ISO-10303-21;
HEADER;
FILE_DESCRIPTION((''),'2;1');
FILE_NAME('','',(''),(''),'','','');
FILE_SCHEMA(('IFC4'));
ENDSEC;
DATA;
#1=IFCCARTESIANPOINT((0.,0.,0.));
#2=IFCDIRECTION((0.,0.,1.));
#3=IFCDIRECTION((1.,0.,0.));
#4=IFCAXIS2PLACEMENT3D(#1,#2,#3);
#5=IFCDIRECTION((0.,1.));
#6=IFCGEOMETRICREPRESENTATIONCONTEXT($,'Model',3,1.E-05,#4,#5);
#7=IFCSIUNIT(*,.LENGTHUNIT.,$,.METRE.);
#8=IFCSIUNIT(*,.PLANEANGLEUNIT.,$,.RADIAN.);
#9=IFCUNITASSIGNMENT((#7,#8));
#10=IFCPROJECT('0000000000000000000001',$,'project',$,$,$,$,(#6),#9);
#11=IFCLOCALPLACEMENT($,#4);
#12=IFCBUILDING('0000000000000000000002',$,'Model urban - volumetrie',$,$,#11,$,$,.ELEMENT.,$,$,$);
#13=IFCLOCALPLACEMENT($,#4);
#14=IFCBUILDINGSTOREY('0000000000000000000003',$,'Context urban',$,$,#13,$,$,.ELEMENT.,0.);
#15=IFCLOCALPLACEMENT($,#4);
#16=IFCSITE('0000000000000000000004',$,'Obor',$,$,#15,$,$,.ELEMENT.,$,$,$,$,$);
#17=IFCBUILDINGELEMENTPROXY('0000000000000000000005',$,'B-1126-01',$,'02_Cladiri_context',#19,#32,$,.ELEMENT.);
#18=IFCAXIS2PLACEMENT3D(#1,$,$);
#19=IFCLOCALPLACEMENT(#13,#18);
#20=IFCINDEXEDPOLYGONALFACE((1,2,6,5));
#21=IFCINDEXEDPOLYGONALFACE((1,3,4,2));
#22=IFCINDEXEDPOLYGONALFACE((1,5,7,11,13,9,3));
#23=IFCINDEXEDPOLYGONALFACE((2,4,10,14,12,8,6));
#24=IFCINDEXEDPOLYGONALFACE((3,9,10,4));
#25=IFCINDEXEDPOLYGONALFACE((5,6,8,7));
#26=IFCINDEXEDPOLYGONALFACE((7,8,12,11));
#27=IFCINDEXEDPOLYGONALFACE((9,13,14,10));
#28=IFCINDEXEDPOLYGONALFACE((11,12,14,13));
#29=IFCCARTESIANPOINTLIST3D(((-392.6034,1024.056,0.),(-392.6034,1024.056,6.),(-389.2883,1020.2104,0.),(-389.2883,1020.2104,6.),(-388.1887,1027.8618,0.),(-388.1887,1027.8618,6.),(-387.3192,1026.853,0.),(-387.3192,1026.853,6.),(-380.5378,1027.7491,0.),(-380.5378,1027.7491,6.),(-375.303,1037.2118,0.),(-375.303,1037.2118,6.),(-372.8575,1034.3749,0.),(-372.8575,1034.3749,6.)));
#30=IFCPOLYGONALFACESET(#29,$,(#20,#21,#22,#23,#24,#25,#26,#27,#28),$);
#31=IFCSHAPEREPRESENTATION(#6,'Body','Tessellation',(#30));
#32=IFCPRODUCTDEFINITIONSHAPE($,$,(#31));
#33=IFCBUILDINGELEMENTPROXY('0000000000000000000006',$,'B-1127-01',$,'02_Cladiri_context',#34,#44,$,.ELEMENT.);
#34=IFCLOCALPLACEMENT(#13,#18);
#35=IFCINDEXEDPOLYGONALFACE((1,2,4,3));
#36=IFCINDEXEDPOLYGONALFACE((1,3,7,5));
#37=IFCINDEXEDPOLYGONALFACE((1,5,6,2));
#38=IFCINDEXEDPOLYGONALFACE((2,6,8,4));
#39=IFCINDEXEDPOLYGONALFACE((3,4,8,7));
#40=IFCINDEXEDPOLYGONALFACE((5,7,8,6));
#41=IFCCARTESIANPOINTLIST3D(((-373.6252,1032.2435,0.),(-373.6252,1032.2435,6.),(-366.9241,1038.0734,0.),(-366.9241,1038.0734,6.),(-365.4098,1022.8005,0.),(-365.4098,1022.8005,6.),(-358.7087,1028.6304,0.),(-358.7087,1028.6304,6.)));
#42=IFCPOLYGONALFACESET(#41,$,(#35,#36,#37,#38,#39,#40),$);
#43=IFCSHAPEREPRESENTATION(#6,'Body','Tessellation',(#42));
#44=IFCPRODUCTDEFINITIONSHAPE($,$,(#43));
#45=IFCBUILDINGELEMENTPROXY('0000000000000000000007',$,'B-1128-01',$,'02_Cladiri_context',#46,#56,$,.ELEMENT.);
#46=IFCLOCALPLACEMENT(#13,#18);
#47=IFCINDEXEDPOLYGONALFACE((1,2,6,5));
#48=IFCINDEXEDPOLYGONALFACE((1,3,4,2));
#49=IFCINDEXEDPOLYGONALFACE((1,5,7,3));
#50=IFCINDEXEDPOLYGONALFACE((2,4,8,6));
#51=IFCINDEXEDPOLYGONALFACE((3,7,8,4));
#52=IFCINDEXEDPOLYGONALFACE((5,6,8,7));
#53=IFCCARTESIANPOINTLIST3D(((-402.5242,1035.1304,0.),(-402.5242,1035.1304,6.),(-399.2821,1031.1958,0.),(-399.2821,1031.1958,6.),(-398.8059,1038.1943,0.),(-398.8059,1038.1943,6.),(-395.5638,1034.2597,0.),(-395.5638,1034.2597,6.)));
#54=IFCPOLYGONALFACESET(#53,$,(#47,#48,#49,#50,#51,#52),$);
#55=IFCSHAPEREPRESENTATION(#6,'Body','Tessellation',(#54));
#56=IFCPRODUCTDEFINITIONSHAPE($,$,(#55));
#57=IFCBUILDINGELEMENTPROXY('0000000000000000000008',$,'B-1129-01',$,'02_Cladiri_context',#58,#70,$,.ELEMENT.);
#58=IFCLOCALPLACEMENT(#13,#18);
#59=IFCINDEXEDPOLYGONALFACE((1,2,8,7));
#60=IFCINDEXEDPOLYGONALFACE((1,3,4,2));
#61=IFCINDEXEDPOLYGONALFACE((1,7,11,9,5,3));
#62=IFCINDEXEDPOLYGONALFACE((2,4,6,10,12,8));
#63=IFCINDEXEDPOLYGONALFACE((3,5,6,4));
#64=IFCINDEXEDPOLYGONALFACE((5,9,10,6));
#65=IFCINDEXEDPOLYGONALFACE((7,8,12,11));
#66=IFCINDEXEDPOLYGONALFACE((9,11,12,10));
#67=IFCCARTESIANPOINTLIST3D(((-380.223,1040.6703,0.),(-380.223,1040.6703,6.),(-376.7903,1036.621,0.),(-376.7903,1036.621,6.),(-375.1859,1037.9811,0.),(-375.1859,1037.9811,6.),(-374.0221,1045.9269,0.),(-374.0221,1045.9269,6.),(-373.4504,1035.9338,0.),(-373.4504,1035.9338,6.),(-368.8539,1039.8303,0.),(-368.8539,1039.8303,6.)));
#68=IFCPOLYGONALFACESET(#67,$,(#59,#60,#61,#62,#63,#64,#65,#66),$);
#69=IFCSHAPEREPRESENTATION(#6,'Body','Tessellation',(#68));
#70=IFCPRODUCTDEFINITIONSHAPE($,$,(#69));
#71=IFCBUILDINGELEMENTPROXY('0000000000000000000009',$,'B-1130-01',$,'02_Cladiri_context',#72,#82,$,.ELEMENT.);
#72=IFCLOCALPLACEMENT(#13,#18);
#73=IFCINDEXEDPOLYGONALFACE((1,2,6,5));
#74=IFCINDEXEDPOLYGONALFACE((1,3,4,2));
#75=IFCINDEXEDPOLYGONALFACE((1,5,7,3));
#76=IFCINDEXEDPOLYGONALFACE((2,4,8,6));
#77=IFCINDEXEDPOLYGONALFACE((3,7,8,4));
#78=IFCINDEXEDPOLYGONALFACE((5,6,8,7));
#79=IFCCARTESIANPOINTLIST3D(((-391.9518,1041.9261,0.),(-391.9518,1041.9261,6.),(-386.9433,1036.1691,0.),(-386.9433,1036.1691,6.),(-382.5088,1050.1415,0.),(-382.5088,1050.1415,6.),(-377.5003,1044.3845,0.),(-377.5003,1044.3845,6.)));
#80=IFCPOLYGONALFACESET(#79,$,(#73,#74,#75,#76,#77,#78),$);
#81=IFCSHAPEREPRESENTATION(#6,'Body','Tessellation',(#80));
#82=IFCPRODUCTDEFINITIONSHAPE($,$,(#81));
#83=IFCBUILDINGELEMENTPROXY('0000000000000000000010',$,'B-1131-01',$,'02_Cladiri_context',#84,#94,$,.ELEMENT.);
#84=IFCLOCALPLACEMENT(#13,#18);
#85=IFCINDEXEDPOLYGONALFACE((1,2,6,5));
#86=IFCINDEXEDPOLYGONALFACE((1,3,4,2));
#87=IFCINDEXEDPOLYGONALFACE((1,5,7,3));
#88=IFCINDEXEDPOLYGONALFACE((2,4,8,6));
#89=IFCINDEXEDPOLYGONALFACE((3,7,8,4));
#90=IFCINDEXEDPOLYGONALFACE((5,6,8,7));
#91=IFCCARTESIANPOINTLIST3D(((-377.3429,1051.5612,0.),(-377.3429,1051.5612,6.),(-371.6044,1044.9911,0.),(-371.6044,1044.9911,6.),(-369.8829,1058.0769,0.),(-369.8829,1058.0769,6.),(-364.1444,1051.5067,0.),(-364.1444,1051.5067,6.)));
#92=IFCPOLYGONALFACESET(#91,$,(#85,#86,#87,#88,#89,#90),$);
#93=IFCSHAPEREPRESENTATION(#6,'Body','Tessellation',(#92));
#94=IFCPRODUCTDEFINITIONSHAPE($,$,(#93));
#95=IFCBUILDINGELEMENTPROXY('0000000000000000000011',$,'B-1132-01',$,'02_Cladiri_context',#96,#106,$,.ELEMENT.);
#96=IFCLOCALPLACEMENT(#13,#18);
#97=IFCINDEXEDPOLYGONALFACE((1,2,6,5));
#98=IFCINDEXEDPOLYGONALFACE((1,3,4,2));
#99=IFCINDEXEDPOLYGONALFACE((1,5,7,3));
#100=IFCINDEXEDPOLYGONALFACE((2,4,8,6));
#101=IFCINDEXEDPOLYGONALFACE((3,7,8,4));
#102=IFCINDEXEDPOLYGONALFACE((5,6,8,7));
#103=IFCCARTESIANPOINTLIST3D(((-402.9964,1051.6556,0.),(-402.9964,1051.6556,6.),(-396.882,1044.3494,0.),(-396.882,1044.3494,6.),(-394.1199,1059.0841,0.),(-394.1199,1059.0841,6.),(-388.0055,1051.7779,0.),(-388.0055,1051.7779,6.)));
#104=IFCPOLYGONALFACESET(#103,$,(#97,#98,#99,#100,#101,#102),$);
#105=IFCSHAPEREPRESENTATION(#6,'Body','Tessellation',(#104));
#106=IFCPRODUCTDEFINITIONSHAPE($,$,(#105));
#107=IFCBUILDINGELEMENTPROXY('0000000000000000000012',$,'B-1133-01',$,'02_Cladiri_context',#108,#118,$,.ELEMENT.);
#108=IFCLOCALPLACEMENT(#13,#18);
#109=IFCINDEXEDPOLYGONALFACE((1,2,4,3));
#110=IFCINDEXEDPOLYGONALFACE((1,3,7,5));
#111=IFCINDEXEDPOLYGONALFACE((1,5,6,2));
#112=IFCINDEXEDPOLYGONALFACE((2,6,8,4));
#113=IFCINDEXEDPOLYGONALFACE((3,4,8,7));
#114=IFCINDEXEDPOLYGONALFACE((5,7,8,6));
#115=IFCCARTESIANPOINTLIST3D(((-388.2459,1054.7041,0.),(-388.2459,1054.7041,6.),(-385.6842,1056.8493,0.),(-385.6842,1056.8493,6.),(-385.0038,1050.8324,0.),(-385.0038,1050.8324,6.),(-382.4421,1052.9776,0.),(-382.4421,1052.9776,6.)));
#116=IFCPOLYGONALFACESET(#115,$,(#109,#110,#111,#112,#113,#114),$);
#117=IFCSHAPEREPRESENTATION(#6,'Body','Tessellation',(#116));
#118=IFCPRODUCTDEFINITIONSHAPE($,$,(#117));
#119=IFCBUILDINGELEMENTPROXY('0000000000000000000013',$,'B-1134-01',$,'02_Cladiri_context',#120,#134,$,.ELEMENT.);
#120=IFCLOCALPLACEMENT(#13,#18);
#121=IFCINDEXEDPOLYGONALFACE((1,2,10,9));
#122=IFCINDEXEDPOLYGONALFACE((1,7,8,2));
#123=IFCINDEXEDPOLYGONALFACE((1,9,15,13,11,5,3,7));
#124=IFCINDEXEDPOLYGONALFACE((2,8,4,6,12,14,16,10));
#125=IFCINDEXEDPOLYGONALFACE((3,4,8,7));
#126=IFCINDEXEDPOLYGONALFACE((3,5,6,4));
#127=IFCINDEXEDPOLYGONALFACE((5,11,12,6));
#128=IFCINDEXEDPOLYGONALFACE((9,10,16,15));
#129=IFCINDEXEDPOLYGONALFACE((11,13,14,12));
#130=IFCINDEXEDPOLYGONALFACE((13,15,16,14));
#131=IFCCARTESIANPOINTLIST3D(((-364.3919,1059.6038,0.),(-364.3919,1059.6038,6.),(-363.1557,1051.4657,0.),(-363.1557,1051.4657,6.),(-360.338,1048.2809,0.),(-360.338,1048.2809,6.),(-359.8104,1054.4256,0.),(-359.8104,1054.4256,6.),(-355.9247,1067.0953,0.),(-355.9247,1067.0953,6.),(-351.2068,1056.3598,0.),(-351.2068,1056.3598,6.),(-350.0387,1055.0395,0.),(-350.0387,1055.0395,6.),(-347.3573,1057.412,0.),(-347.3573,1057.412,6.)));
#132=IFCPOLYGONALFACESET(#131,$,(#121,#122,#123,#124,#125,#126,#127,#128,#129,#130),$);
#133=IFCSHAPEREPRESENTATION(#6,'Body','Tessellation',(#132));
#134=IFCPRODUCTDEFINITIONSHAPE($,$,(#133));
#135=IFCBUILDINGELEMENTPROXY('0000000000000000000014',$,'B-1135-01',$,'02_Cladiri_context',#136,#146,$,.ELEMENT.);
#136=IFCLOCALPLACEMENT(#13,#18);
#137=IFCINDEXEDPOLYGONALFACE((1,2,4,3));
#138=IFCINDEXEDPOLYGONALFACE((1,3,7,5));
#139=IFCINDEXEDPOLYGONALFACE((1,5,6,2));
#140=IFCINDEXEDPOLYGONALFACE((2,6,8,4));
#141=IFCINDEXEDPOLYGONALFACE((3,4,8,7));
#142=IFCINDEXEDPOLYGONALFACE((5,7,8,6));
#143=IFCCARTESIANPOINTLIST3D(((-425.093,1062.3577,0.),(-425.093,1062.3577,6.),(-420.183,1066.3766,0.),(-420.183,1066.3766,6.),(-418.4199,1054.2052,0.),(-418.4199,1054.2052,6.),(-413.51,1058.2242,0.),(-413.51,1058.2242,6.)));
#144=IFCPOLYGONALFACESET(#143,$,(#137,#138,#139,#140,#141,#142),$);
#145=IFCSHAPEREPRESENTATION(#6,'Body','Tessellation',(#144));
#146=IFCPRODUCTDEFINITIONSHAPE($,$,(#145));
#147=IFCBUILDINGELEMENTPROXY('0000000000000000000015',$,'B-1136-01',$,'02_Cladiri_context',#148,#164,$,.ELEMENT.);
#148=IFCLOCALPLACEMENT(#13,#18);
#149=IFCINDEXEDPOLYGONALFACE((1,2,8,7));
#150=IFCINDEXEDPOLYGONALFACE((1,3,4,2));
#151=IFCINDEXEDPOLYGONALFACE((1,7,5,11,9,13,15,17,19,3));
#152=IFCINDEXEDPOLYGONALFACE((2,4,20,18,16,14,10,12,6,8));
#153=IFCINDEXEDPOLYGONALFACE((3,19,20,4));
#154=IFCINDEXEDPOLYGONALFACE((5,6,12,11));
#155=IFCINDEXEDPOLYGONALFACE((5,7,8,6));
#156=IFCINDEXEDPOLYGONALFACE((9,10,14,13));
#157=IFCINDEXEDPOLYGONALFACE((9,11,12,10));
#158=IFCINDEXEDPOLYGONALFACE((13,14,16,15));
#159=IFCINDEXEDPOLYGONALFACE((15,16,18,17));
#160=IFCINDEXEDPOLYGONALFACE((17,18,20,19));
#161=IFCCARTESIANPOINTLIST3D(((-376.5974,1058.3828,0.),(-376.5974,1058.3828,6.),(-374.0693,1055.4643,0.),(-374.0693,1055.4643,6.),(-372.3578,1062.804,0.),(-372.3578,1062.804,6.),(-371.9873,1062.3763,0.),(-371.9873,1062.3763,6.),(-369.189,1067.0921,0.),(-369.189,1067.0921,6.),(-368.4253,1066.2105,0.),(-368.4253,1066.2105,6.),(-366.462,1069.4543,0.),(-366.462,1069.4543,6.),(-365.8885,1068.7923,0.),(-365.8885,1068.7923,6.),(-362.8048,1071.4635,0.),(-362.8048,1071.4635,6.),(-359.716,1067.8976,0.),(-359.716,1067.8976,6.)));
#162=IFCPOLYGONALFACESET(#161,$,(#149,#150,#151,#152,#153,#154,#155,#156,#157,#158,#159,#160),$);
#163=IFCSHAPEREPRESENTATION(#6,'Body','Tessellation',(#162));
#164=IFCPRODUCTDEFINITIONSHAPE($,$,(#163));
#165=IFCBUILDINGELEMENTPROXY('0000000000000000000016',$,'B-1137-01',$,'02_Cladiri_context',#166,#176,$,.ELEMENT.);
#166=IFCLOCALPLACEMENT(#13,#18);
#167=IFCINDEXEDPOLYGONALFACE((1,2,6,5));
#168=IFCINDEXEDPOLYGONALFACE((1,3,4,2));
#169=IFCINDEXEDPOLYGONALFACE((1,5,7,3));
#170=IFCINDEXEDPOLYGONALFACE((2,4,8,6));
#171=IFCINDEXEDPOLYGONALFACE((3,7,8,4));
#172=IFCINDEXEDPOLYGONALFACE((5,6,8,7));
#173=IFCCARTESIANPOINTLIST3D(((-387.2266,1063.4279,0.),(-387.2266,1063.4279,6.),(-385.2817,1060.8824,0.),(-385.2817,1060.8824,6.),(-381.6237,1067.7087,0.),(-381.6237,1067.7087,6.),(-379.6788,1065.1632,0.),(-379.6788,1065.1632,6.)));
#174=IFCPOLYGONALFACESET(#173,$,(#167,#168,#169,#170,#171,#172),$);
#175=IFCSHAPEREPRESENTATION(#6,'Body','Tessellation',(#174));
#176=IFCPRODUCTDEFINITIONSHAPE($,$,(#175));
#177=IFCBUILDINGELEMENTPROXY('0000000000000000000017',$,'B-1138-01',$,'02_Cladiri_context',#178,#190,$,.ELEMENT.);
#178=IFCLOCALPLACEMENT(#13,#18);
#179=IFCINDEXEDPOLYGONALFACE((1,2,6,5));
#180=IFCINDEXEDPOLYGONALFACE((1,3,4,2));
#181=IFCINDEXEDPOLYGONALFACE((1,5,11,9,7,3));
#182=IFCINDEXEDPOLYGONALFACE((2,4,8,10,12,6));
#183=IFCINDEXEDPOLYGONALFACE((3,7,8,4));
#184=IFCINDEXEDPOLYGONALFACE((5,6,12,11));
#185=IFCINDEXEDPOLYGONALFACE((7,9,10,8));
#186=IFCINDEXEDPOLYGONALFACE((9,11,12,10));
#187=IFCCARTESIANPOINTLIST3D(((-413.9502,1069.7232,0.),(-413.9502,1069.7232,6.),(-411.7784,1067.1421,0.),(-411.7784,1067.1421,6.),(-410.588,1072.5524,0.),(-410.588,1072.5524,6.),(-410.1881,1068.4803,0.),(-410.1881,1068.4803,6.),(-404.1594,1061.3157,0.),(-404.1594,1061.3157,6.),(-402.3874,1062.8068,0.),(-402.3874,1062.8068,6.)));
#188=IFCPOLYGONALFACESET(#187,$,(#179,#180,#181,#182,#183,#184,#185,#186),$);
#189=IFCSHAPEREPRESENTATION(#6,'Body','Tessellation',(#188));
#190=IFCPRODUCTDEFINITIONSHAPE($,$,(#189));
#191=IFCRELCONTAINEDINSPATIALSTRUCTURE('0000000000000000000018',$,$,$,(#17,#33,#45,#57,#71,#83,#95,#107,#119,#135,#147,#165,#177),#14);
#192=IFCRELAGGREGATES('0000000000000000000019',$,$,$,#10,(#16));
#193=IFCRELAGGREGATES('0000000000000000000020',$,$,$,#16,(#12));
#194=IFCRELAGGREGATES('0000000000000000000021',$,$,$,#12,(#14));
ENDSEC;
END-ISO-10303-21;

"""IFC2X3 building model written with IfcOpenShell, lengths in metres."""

from ifc_helpers import new_model, si_unit, direction, origin_with_axes, place, context, project, spatial, polyline, outline, extrude, element, save


model = new_model("IFC2X3")

# Units and contexts
model_context = context("Model", 3, precision=1e-05, world=origin_with_axes(), true_north=direction((0.0, 1.0)))
ifc_project = project(units=[si_unit("LENGTHUNIT", "METRE"), si_unit("PLANEANGLEUNIT", "RADIAN")], contexts=[model_context])

# Site, building, storey
site_placement = place(None, origin_with_axes())
site = spatial("IfcSite", under=ifc_project, at=site_placement, Name="Obor", CompositionType="ELEMENT")
building_placement = place(None, origin_with_axes())
building = spatial("IfcBuilding", under=site, at=building_placement, Name="Model urban - volumetrie", CompositionType="ELEMENT")
storey_placement = place(None, origin_with_axes())
storey = spatial("IfcBuildingStorey", under=building, at=storey_placement, Name="Context urban", CompositionType="ELEMENT", Elevation=0.0)

# Building element proxies
proxy_1_placement = place(None, origin_with_axes())
element("IfcBuildingElementProxy", 1, at=proxy_1_placement, inside=storey, Name="B-1126-01", ObjectType="02_Cladiri_context", CompositionType="ELEMENT", context=model_context, shape_type="SweptSolid", body=[
    extrude(outline(polyline([(-389.2883, 1020.2104), (-380.5378, 1027.7491), (-372.8575, 1034.3749), (-375.303, 1037.2118), (-387.3192, 1026.853), (-388.1887, 1027.8618), (-392.6034, 1024.056), (-389.2883, 1020.2104)])), origin_with_axes(), (0.0, 0.0, 1.0), 6.0),
])
proxy_2_placement = place(None, origin_with_axes())
element("IfcBuildingElementProxy", 2, at=proxy_2_placement, inside=storey, Name="B-1127-01", ObjectType="02_Cladiri_context", CompositionType="ELEMENT", context=model_context, shape_type="SweptSolid", body=[
    extrude(outline(polyline([(-365.4098, 1022.8005), (-358.7087, 1028.6304), (-366.9241, 1038.0734), (-373.6252, 1032.2435), (-365.4098, 1022.8005)])), origin_with_axes(), (0.0, 0.0, 1.0), 6.0),
])
proxy_3_placement = place(None, origin_with_axes())
element("IfcBuildingElementProxy", 3, at=proxy_3_placement, inside=storey, Name="B-1128-01", ObjectType="02_Cladiri_context", CompositionType="ELEMENT", context=model_context, shape_type="SweptSolid", body=[
    extrude(outline(polyline([(-399.2821, 1031.1958), (-395.5638, 1034.2597), (-398.8059, 1038.1943), (-402.5242, 1035.1304), (-399.2821, 1031.1958)])), origin_with_axes(), (0.0, 0.0, 1.0), 6.0),
])
proxy_4_placement = place(None, origin_with_axes())
element("IfcBuildingElementProxy", 4, at=proxy_4_placement, inside=storey, Name="B-1129-01", ObjectType="02_Cladiri_context", CompositionType="ELEMENT", context=model_context, shape_type="SweptSolid", body=[
    extrude(outline(polyline([(-373.4504, 1035.9338), (-368.8539, 1039.8303), (-374.0221, 1045.9269), (-380.223, 1040.6703), (-376.7903, 1036.621), (-375.1859, 1037.9811), (-373.4504, 1035.9338)])), origin_with_axes(), (0.0, 0.0, 1.0), 6.0),
])
proxy_5_placement = place(None, origin_with_axes())
element("IfcBuildingElementProxy", 5, at=proxy_5_placement, inside=storey, Name="B-1130-01", ObjectType="02_Cladiri_context", CompositionType="ELEMENT", context=model_context, shape_type="SweptSolid", body=[
    extrude(outline(polyline([(-382.5088, 1050.1415), (-391.9518, 1041.9261), (-386.9433, 1036.1691), (-377.5003, 1044.3845), (-382.5088, 1050.1415)])), origin_with_axes(), (0.0, 0.0, 1.0), 6.0),
])
proxy_6_placement = place(None, origin_with_axes())
element("IfcBuildingElementProxy", 6, at=proxy_6_placement, inside=storey, Name="B-1131-01", ObjectType="02_Cladiri_context", CompositionType="ELEMENT", context=model_context, shape_type="SweptSolid", body=[
    extrude(outline(polyline([(-364.1444, 1051.5067), (-369.8829, 1058.0769), (-377.3429, 1051.5612), (-371.6044, 1044.9911), (-364.1444, 1051.5067)])), origin_with_axes(), (0.0, 0.0, 1.0), 6.0),
])
proxy_7_placement = place(None, origin_with_axes())
element("IfcBuildingElementProxy", 7, at=proxy_7_placement, inside=storey, Name="B-1132-01", ObjectType="02_Cladiri_context", CompositionType="ELEMENT", context=model_context, shape_type="SweptSolid", body=[
    extrude(outline(polyline([(-388.0055, 1051.7779), (-394.1199, 1059.0841), (-402.9964, 1051.6556), (-396.882, 1044.3494), (-388.0055, 1051.7779)])), origin_with_axes(), (0.0, 0.0, 1.0), 6.0),
])
proxy_8_placement = place(None, origin_with_axes())
element("IfcBuildingElementProxy", 8, at=proxy_8_placement, inside=storey, Name="B-1133-01", ObjectType="02_Cladiri_context", CompositionType="ELEMENT", context=model_context, shape_type="SweptSolid", body=[
    extrude(outline(polyline([(-388.2459, 1054.7041), (-385.0038, 1050.8324), (-382.4421, 1052.9776), (-385.6842, 1056.8493), (-388.2459, 1054.7041)])), origin_with_axes(), (0.0, 0.0, 1.0), 6.0),
])
proxy_9_placement = place(None, origin_with_axes())
element("IfcBuildingElementProxy", 9, at=proxy_9_placement, inside=storey, Name="B-1134-01", ObjectType="02_Cladiri_context", CompositionType="ELEMENT", context=model_context, shape_type="SweptSolid", body=[
    extrude(outline(polyline([(-359.8104, 1054.4256), (-363.1557, 1051.4657), (-360.338, 1048.2809), (-351.2068, 1056.3598), (-350.0387, 1055.0395), (-347.3573, 1057.412), (-355.9247, 1067.0953), (-364.3919, 1059.6038), (-359.8104, 1054.4256)])), origin_with_axes(), (0.0, 0.0, 1.0), 6.0),
])
proxy_10_placement = place(None, origin_with_axes())
element("IfcBuildingElementProxy", 10, at=proxy_10_placement, inside=storey, Name="B-1135-01", ObjectType="02_Cladiri_context", CompositionType="ELEMENT", context=model_context, shape_type="SweptSolid", body=[
    extrude(outline(polyline([(-413.51, 1058.2242), (-420.183, 1066.3766), (-425.093, 1062.3577), (-418.4199, 1054.2052), (-413.51, 1058.2242)])), origin_with_axes(), (0.0, 0.0, 1.0), 6.0),
])
proxy_11_placement = place(None, origin_with_axes())
element("IfcBuildingElementProxy", 11, at=proxy_11_placement, inside=storey, Name="B-1136-01", ObjectType="02_Cladiri_context", CompositionType="ELEMENT", context=model_context, shape_type="SweptSolid", body=[
    extrude(outline(polyline([(-368.4253, 1066.2105), (-372.3578, 1062.804), (-371.9873, 1062.3763), (-376.5974, 1058.3828), (-374.0693, 1055.4643), (-359.716, 1067.8976), (-362.8048, 1071.4635), (-365.8885, 1068.7923), (-366.462, 1069.4543), (-369.189, 1067.0921), (-368.4253, 1066.2105)])), origin_with_axes(), (0.0, 0.0, 1.0), 6.0),
])
proxy_12_placement = place(None, origin_with_axes())
element("IfcBuildingElementProxy", 12, at=proxy_12_placement, inside=storey, Name="B-1137-01", ObjectType="02_Cladiri_context", CompositionType="ELEMENT", context=model_context, shape_type="SweptSolid", body=[
    extrude(outline(polyline([(-385.2817, 1060.8824), (-379.6788, 1065.1632), (-381.6237, 1067.7087), (-387.2266, 1063.4279), (-385.2817, 1060.8824)])), origin_with_axes(), (0.0, 0.0, 1.0), 6.0),
])
proxy_13_placement = place(None, origin_with_axes())
element("IfcBuildingElementProxy", 13, at=proxy_13_placement, inside=storey, Name="B-1138-01", ObjectType="02_Cladiri_context", CompositionType="ELEMENT", context=model_context, shape_type="SweptSolid", body=[
    extrude(outline(polyline([(-404.1594, 1061.3157), (-402.3874, 1062.8068), (-410.588, 1072.5524), (-413.9502, 1069.7232), (-411.7784, 1067.1421), (-410.1881, 1068.4803), (-404.1594, 1061.3157)])), origin_with_axes(), (0.0, 0.0, 1.0), 6.0),
])

save(model, "model.ifc")
